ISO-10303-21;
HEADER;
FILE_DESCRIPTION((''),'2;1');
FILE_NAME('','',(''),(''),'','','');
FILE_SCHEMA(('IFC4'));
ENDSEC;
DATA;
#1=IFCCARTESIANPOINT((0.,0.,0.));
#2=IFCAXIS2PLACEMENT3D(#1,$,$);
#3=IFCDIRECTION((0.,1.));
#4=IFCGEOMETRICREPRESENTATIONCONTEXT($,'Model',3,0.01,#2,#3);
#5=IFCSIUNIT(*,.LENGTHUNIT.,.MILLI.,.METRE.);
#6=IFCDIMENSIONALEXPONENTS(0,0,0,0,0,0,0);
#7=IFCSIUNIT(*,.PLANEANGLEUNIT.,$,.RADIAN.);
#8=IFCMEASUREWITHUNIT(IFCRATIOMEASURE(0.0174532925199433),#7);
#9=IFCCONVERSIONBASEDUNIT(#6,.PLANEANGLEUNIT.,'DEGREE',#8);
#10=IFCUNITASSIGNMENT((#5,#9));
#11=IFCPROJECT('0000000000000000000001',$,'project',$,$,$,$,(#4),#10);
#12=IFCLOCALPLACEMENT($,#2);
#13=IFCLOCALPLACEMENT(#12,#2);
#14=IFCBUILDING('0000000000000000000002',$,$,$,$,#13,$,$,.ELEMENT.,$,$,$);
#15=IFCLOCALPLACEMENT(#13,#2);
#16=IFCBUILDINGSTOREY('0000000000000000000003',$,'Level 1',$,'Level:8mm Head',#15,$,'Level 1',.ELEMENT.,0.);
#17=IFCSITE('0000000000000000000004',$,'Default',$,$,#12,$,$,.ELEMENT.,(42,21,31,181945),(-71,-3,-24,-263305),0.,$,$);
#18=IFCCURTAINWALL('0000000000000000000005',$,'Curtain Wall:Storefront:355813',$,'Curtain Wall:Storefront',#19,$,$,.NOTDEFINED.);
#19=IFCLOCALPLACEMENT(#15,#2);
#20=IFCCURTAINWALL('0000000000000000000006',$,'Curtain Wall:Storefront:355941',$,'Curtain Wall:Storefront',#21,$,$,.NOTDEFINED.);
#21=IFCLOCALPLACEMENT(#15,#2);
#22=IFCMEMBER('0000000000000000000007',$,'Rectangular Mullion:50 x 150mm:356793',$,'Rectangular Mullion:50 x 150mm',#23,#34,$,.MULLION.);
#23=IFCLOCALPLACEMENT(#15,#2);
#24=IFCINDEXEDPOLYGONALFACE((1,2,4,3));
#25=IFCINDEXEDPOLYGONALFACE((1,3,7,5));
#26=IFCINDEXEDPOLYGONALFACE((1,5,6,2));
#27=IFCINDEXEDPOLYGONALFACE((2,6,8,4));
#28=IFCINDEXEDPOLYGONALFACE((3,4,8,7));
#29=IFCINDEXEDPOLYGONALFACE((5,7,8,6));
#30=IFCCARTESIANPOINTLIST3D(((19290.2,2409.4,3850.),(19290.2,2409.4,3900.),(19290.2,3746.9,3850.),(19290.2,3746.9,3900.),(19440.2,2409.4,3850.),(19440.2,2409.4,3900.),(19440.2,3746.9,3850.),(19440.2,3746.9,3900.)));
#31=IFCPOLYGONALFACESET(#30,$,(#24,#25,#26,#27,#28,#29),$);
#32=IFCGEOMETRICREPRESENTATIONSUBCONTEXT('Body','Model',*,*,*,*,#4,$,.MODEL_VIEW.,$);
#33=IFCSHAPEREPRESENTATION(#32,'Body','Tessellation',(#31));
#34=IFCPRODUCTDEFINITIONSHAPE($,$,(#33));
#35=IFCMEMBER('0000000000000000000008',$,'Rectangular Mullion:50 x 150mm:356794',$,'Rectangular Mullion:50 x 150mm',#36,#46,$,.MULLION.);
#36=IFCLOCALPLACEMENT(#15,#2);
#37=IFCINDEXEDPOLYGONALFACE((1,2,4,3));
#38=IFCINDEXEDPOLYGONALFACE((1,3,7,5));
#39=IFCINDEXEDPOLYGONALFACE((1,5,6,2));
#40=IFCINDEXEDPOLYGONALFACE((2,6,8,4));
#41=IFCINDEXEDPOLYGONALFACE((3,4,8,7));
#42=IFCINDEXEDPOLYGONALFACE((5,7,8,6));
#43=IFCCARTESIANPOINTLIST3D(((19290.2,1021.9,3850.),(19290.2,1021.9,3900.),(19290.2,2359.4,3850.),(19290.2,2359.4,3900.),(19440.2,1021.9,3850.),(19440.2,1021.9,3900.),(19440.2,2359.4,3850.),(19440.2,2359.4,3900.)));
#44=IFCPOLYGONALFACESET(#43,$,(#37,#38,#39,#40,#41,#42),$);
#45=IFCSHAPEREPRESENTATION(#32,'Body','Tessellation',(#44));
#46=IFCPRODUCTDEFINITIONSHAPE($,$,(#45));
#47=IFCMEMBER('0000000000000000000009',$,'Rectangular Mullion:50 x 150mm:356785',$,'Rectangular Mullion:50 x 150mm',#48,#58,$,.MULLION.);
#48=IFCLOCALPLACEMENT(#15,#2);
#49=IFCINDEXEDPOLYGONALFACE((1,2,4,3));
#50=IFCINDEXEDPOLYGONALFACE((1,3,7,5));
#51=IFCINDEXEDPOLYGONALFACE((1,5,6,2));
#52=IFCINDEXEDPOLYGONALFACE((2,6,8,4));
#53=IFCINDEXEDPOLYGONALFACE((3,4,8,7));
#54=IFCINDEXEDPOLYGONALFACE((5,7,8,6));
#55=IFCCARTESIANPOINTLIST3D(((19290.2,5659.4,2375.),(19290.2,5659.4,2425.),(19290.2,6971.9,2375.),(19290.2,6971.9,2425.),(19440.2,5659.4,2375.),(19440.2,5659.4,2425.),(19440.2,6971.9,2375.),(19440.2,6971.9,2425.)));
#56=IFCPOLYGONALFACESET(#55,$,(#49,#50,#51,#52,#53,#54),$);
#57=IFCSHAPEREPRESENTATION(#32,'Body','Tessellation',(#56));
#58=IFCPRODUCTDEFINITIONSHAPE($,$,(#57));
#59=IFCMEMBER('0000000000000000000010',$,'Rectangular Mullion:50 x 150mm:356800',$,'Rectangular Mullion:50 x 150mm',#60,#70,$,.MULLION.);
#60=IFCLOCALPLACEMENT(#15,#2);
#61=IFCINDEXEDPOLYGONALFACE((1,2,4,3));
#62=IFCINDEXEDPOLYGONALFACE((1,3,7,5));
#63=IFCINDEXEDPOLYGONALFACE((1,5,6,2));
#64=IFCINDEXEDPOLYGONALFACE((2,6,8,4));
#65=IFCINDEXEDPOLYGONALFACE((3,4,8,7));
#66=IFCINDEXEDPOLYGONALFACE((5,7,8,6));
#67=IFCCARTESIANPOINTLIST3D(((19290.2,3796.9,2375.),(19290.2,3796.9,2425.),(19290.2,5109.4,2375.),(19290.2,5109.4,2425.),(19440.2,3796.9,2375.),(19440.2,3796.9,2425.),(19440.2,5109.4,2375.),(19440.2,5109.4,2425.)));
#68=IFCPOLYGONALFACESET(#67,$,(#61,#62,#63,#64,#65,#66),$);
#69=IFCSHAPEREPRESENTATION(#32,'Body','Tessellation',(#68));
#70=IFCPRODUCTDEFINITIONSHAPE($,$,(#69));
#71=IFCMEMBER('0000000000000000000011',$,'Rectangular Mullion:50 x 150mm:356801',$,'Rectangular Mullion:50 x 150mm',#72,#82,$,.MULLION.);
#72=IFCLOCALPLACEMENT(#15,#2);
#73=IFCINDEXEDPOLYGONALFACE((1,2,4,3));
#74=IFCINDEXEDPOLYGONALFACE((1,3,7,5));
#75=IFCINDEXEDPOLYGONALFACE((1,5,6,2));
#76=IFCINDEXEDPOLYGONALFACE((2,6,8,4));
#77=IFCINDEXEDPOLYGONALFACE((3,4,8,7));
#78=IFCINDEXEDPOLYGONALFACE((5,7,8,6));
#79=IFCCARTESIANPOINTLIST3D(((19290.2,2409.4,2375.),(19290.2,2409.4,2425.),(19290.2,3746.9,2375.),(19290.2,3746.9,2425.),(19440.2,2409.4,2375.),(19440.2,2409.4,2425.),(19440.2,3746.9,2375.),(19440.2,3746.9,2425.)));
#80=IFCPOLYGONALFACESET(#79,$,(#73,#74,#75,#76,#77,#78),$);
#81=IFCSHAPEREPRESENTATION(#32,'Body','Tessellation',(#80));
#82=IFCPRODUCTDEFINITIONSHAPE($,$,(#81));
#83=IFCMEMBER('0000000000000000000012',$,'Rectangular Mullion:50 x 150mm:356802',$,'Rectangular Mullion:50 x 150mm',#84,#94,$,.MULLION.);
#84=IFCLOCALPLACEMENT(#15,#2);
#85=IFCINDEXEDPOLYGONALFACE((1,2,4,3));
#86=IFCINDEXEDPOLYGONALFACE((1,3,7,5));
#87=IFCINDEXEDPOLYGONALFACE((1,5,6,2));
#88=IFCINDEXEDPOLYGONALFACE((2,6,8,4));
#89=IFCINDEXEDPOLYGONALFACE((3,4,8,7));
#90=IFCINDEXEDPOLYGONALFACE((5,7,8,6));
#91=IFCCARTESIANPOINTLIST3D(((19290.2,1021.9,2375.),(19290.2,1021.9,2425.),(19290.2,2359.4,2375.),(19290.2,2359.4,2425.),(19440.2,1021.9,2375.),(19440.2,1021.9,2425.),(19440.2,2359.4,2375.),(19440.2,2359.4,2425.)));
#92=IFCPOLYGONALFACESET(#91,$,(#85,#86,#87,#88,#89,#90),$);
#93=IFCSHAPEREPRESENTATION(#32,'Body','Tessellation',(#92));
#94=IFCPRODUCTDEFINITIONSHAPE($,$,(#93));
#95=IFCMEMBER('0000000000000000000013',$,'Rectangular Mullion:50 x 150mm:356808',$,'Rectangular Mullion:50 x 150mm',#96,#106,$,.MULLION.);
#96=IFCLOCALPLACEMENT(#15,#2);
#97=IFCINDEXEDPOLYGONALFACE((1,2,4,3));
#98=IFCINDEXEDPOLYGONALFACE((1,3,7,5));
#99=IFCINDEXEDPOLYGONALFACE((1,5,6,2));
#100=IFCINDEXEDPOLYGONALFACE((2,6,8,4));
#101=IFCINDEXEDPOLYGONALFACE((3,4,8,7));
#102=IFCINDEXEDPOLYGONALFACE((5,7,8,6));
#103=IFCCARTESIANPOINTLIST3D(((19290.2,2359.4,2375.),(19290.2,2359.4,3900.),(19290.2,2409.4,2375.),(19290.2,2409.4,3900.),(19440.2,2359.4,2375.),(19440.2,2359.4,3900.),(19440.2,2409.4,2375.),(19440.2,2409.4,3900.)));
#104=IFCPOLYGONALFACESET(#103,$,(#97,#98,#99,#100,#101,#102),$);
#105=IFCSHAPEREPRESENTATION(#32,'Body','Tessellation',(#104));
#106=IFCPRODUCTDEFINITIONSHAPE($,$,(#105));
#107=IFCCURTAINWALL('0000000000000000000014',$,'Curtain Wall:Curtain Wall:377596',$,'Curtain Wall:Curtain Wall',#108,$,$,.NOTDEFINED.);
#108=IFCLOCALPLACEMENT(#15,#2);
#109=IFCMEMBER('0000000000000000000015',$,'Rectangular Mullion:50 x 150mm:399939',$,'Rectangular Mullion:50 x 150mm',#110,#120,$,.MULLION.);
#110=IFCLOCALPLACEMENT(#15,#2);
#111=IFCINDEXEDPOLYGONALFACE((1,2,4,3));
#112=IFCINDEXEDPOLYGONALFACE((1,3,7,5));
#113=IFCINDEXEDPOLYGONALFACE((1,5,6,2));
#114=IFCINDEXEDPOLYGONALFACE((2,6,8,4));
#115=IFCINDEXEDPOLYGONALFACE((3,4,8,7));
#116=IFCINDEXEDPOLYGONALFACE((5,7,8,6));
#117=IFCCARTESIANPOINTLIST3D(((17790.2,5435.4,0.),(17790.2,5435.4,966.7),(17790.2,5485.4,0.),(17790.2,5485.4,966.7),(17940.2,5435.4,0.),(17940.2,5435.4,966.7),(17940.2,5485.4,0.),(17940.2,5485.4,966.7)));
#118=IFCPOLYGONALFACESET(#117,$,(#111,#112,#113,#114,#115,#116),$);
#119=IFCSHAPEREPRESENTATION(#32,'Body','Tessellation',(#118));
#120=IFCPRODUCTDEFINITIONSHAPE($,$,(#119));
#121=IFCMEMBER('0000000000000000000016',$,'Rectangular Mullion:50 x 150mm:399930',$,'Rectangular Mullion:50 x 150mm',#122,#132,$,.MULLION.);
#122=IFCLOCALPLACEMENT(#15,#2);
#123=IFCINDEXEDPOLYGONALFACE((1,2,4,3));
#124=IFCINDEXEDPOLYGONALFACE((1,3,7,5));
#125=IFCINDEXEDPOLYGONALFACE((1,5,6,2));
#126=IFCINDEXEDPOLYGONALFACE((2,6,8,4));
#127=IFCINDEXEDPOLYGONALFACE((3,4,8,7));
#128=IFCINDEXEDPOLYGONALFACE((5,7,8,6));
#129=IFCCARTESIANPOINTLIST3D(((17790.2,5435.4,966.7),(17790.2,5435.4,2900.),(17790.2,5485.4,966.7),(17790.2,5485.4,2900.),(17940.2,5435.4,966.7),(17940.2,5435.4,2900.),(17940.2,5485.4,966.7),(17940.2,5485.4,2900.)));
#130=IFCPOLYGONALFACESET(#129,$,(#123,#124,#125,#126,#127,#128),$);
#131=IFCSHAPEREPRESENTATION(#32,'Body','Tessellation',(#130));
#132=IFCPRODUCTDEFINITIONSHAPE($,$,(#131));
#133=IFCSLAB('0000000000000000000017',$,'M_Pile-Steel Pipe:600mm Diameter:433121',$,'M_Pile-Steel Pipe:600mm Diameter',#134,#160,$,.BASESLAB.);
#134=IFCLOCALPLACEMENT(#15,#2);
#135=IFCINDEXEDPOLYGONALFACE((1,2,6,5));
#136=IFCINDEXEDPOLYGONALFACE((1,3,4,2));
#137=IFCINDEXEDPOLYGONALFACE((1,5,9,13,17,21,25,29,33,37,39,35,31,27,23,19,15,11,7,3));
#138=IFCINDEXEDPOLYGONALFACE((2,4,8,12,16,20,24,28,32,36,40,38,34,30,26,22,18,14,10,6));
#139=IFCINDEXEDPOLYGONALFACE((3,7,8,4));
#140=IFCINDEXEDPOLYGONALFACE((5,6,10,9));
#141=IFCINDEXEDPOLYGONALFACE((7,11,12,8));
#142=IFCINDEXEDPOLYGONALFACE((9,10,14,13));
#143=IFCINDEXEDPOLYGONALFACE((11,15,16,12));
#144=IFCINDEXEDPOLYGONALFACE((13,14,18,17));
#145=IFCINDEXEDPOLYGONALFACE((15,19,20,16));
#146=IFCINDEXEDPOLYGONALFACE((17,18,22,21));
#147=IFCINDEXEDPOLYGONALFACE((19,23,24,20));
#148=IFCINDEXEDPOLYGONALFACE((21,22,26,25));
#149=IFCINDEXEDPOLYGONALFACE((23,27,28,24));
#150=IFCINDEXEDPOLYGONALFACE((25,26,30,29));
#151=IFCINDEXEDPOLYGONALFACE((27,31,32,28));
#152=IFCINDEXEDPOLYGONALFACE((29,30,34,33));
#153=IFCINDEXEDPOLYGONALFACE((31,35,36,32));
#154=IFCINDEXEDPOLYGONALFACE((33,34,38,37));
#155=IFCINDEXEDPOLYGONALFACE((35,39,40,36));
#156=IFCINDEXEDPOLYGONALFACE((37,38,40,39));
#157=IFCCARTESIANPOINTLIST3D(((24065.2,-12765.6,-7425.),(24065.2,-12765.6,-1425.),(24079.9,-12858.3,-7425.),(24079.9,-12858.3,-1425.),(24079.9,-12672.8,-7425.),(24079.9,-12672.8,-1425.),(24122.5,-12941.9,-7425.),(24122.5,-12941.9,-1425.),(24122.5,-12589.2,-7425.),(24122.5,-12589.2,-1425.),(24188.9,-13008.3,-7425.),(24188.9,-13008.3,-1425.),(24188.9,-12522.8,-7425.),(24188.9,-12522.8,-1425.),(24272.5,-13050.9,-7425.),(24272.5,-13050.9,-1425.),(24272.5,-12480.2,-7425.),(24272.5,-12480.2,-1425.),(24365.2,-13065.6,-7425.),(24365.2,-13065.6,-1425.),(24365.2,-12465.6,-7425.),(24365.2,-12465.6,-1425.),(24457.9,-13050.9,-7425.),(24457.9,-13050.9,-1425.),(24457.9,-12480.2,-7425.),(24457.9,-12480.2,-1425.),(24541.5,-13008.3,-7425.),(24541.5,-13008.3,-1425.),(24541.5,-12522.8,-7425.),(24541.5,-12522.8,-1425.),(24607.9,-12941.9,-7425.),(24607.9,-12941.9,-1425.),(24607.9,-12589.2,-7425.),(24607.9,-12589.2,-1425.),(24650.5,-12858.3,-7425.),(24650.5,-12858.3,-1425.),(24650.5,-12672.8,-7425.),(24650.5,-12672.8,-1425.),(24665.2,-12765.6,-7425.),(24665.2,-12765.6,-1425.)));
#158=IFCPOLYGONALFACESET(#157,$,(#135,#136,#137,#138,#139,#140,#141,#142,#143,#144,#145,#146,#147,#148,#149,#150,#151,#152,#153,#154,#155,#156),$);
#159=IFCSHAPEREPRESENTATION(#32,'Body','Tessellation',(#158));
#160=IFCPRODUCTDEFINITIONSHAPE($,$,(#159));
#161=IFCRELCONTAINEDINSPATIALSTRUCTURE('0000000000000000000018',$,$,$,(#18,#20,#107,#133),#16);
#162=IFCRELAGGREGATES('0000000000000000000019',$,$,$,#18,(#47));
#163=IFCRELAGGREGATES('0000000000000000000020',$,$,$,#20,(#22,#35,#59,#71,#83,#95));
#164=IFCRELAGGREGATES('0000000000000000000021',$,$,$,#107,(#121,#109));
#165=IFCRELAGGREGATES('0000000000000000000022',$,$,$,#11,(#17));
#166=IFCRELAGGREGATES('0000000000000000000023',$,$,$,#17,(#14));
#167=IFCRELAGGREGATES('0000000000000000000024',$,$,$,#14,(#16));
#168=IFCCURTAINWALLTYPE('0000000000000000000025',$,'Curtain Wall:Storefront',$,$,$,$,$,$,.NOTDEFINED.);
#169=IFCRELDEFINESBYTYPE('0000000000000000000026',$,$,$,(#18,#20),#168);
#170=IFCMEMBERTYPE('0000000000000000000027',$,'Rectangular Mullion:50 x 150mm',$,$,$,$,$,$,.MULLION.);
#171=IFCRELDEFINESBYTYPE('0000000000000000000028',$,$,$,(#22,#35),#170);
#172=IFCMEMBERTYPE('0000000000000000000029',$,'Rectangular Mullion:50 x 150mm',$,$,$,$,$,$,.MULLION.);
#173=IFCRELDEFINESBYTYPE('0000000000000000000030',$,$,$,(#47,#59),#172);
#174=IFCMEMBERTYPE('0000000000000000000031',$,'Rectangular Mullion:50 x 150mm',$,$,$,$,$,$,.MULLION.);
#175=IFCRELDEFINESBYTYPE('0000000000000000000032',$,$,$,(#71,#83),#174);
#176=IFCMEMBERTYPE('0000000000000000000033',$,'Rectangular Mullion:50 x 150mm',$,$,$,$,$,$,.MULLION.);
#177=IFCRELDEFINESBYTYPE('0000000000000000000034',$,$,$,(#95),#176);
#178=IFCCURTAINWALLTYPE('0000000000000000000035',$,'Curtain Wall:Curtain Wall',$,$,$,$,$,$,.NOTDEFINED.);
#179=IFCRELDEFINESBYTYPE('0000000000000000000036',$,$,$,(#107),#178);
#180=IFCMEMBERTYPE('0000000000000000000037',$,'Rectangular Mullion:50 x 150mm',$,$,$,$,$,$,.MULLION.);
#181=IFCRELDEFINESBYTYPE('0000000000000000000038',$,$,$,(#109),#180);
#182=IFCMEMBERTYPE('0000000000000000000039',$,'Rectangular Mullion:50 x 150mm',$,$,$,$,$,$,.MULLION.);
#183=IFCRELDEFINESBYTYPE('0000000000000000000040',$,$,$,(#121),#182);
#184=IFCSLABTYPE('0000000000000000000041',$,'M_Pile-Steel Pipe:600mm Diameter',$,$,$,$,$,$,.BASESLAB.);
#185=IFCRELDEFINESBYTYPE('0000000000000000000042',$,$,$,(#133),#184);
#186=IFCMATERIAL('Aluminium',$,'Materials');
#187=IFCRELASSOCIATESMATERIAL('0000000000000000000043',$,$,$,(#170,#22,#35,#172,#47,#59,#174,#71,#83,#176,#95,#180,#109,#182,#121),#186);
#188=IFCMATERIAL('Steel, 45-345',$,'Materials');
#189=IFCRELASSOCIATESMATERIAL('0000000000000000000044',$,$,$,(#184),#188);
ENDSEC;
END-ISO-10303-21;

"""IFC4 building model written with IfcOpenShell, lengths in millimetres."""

from ifc_helpers import new_model, entity, si_unit, converted_unit, direction, frame, origin, place, context, subcontext, project, spatial, indexed_curve, outline, extrude, source, transform, mapped, material, type_object, type_shapes, element, aggregate, save


model = new_model("IFC4")

# Units and contexts
model_context = context("Model", 3, precision=0.01, world=origin(), true_north=direction((0.0, 1.0)))
body_context = subcontext(model_context, "Body", "Model", "MODEL_VIEW")
ifc_project = project(units=[si_unit("LENGTHUNIT", "METRE", prefix="MILLI"), converted_unit("PLANEANGLEUNIT", "DEGREE", entity("IfcRatioMeasure", 0.0174532925199433), si_unit("PLANEANGLEUNIT", "RADIAN"), dimensions=[0, 0, 0, 0, 0, 0, 0])], contexts=[model_context])

# Site, building, storey
site_placement = place(None, origin())
site = spatial("IfcSite", under=ifc_project, at=site_placement, Name="Default", CompositionType="ELEMENT", RefLatitude=(42, 21, 31, 181945), RefLongitude=(-71, -3, -24, -263305), RefElevation=0.0)
building_placement = place(site_placement, origin())
building = spatial("IfcBuilding", under=site, at=building_placement, CompositionType="ELEMENT")
storey_placement = place(building_placement, origin())
storey = spatial("IfcBuildingStorey", under=building, at=storey_placement, Name="Level 1", ObjectType="Level:8mm Head", LongName="Level 1", CompositionType="ELEMENT", Elevation=0.0)

# Curtain walls
curtain_wall_type_1 = type_object("IfcCurtainWallType", Name="Curtain Wall:Storefront", PredefinedType="NOTDEFINED")
curtain_wall_1_placement = place(storey_placement, origin())
curtain_wall_1 = element("IfcCurtainWall", 1, at=curtain_wall_1_placement, inside=storey, type_object=curtain_wall_type_1, Name="Curtain Wall:Storefront:355813", ObjectType="Curtain Wall:Storefront", PredefinedType="NOTDEFINED")
ifc_material_1 = material(Name="Aluminium", Category="Materials")
curtain_wall_2_placement = place(storey_placement, origin())
curtain_wall_2 = element("IfcCurtainWall", 2, at=curtain_wall_2_placement, inside=storey, type_object=curtain_wall_type_1, Name="Curtain Wall:Storefront:355941", ObjectType="Curtain Wall:Storefront", PredefinedType="NOTDEFINED")

# Members
member_type_1 = type_object("IfcMemberType", Name="Rectangular Mullion:50 x 150mm", PredefinedType="MULLION", material=ifc_material_1)
shared_shape_1 = source(origin(), body_context, "Body", "SweptSolid", [
    extrude(outline(indexed_curve([(-75.0, -25.0), (75.0, -25.0), (75.0, 25.0), (-75.0, 25.0), (-75.0, -25.0)], self_intersect=False)), frame((-25.0, 0.0, -1337.5), z_axis=(0.0, 0.0, 1.0), x_axis=(0.0, -1.0, 0.0)), (0.0, 0.0, 1.0), 1337.5),
])
type_shapes(member_type_1, [shared_shape_1])
member_1_placement = place(storey_placement, frame((19365.2, 2409.4, 3900.0), z_axis=(0.0, -1.0, 0.0), x_axis=(0.0, 0.0, 1.0)))
member_1 = element("IfcMember", 3, at=member_1_placement, type_object=member_type_1, material=ifc_material_1, Name="Rectangular Mullion:50 x 150mm:356793", ObjectType="Rectangular Mullion:50 x 150mm", PredefinedType="MULLION", context=body_context, shape_type="MappedRepresentation", body=[
    mapped(shared_shape_1, transform((0.0, 0.0, 0.0), scale=1.0)),
])
member_2_placement = place(storey_placement, frame((19365.2, 1021.9, 3900.0), z_axis=(0.0, -1.0, 0.0), x_axis=(0.0, 0.0, 1.0)))
member_2 = element("IfcMember", 4, at=member_2_placement, type_object=member_type_1, material=ifc_material_1, Name="Rectangular Mullion:50 x 150mm:356794", ObjectType="Rectangular Mullion:50 x 150mm", PredefinedType="MULLION", context=body_context, shape_type="MappedRepresentation", body=[
    mapped(shared_shape_1, transform((0.0, 0.0, 0.0), scale=1.0)),
])
member_type_2 = type_object("IfcMemberType", Name="Rectangular Mullion:50 x 150mm", PredefinedType="MULLION", material=ifc_material_1)
shared_shape_2 = source(origin(), body_context, "Body", "SweptSolid", [
    extrude(outline(indexed_curve([(-75.0, -25.0), (75.0, -25.0), (75.0, 25.0), (-75.0, 25.0), (-75.0, -25.0)], self_intersect=False)), frame((0.0, 0.0, -1312.5), z_axis=(0.0, 0.0, 1.0), x_axis=(0.0, -1.0, 0.0)), (0.0, 0.0, 1.0), 1312.5),
])
type_shapes(member_type_2, [shared_shape_2])
member_3_placement = place(storey_placement, frame((19365.2, 5659.4, 2400.0), z_axis=(0.0, -1.0, 0.0), x_axis=(0.0, 0.0, 1.0)))
member_3 = element("IfcMember", 5, at=member_3_placement, type_object=member_type_2, material=ifc_material_1, Name="Rectangular Mullion:50 x 150mm:356785", ObjectType="Rectangular Mullion:50 x 150mm", PredefinedType="MULLION", context=body_context, shape_type="MappedRepresentation", body=[
    mapped(shared_shape_2, transform((0.0, 0.0, 0.0), scale=1.0)),
])
member_4_placement = place(storey_placement, frame((19365.2, 3796.9, 2400.0), z_axis=(0.0, -1.0, 0.0), x_axis=(0.0, 0.0, 1.0)))
member_4 = element("IfcMember", 6, at=member_4_placement, type_object=member_type_2, material=ifc_material_1, Name="Rectangular Mullion:50 x 150mm:356800", ObjectType="Rectangular Mullion:50 x 150mm", PredefinedType="MULLION", context=body_context, shape_type="MappedRepresentation", body=[
    mapped(shared_shape_2, transform((0.0, 0.0, 0.0), scale=1.0)),
])
member_type_3 = type_object("IfcMemberType", Name="Rectangular Mullion:50 x 150mm", PredefinedType="MULLION", material=ifc_material_1)
shared_shape_3 = source(origin(), body_context, "Body", "SweptSolid", [
    extrude(outline(indexed_curve([(-75.0, -25.0), (75.0, -25.0), (75.0, 25.0), (-75.0, 25.0), (-75.0, -25.0)], self_intersect=False)), frame((0.0, 0.0, -1337.5), z_axis=(0.0, 0.0, 1.0), x_axis=(0.0, -1.0, 0.0)), (0.0, 0.0, 1.0), 1337.5),
])
type_shapes(member_type_3, [shared_shape_3])
member_5_placement = place(storey_placement, frame((19365.2, 2409.4, 2400.0), z_axis=(0.0, -1.0, 0.0), x_axis=(0.0, 0.0, 1.0)))
member_5 = element("IfcMember", 7, at=member_5_placement, type_object=member_type_3, material=ifc_material_1, Name="Rectangular Mullion:50 x 150mm:356801", ObjectType="Rectangular Mullion:50 x 150mm", PredefinedType="MULLION", context=body_context, shape_type="MappedRepresentation", body=[
    mapped(shared_shape_3, transform((0.0, 0.0, 0.0), scale=1.0)),
])
member_6_placement = place(storey_placement, frame((19365.2, 1021.9, 2400.0), z_axis=(0.0, -1.0, 0.0), x_axis=(0.0, 0.0, 1.0)))
member_6 = element("IfcMember", 8, at=member_6_placement, type_object=member_type_3, material=ifc_material_1, Name="Rectangular Mullion:50 x 150mm:356802", ObjectType="Rectangular Mullion:50 x 150mm", PredefinedType="MULLION", context=body_context, shape_type="MappedRepresentation", body=[
    mapped(shared_shape_3, transform((0.0, 0.0, 0.0), scale=1.0)),
])
member_type_4 = type_object("IfcMemberType", Name="Rectangular Mullion:50 x 150mm", PredefinedType="MULLION", material=ifc_material_1)
shared_shape_4 = source(origin(), body_context, "Body", "SweptSolid", [
    extrude(outline(indexed_curve([(-75.0, -25.0), (75.0, -25.0), (75.0, 25.0), (-75.0, 25.0), (-75.0, -25.0)], self_intersect=False)), frame((0.0, 0.0, -1525.0), z_axis=(0.0, 0.0, 1.0), x_axis=(0.0, -1.0, 0.0)), (0.0, 0.0, 1.0), 1525.0),
])
type_shapes(member_type_4, [shared_shape_4])
member_7_placement = place(storey_placement, frame((19365.2, 2384.4, 2375.0), z_axis=(0.0, 0.0, -1.0), x_axis=(0.0, -1.0, 0.0)))
member_7 = element("IfcMember", 9, at=member_7_placement, type_object=member_type_4, material=ifc_material_1, Name="Rectangular Mullion:50 x 150mm:356808", ObjectType="Rectangular Mullion:50 x 150mm", PredefinedType="MULLION", context=body_context, shape_type="MappedRepresentation", body=[
    mapped(shared_shape_4, transform((0.0, 0.0, 0.0), scale=1.0)),
])

# Curtain wall, members
curtain_wall_type_2 = type_object("IfcCurtainWallType", Name="Curtain Wall:Curtain Wall", PredefinedType="NOTDEFINED")
curtain_wall_3_placement = place(storey_placement, origin())
curtain_wall_3 = element("IfcCurtainWall", 10, at=curtain_wall_3_placement, inside=storey, type_object=curtain_wall_type_2, Name="Curtain Wall:Curtain Wall:377596", ObjectType="Curtain Wall:Curtain Wall", PredefinedType="NOTDEFINED")
member_type_5 = type_object("IfcMemberType", Name="Rectangular Mullion:50 x 150mm", PredefinedType="MULLION", material=ifc_material_1)
shared_shape_5 = source(origin(), body_context, "Body", "SweptSolid", [
    extrude(outline(indexed_curve([(-75.0, -25.0), (75.0, -25.0), (75.0, 25.0), (-75.0, 25.0), (-75.0, -25.0)], self_intersect=False)), frame((-25.0, 0.0, -966.7), z_axis=(0.0, 0.0, 1.0), x_axis=(0.0, -1.0, 0.0)), (0.0, 0.0, 1.0), 966.7),
])
type_shapes(member_type_5, [shared_shape_5])
member_8_placement = place(storey_placement, frame((17865.2, 5435.4, 966.7), z_axis=(0.0, 0.0, 1.0), x_axis=(0.0, -1.0, 0.0)))
member_8 = element("IfcMember", 11, at=member_8_placement, type_object=member_type_5, material=ifc_material_1, Name="Rectangular Mullion:50 x 150mm:399939", ObjectType="Rectangular Mullion:50 x 150mm", PredefinedType="MULLION", context=body_context, shape_type="MappedRepresentation", body=[
    mapped(shared_shape_5, transform((0.0, 0.0, 0.0), scale=1.0)),
])
member_type_6 = type_object("IfcMemberType", Name="Rectangular Mullion:50 x 150mm", PredefinedType="MULLION", material=ifc_material_1)
shared_shape_6 = source(origin(), body_context, "Body", "SweptSolid", [
    extrude(outline(indexed_curve([(-75.0, -25.0), (75.0, -25.0), (75.0, 25.0), (-75.0, 25.0), (-75.0, -25.0)], self_intersect=False)), frame((-25.0, 0.0, -1933.3), z_axis=(0.0, 0.0, 1.0), x_axis=(0.0, -1.0, 0.0)), (0.0, 0.0, 1.0), 1933.3),
])
type_shapes(member_type_6, [shared_shape_6])
member_9_placement = place(storey_placement, frame((17865.2, 5435.4, 2900.0), z_axis=(0.0, 0.0, 1.0), x_axis=(0.0, -1.0, 0.0)))
member_9 = element("IfcMember", 12, at=member_9_placement, type_object=member_type_6, material=ifc_material_1, Name="Rectangular Mullion:50 x 150mm:399930", ObjectType="Rectangular Mullion:50 x 150mm", PredefinedType="MULLION", context=body_context, shape_type="MappedRepresentation", body=[
    mapped(shared_shape_6, transform((0.0, 0.0, 0.0), scale=1.0)),
])

aggregate(curtain_wall_1, [member_3])

# Slab
ifc_material_2 = material(Name="Steel, 45-345", Category="Materials")
slab_type_1 = type_object("IfcSlabType", Name="M_Pile-Steel Pipe:600mm Diameter", PredefinedType="BASESLAB", material=ifc_material_2)
slab_1_placement = place(building_placement, origin())
element("IfcSlab", 13, at=slab_1_placement, inside=storey, type_object=slab_type_1, Name="M_Pile-Steel Pipe:600mm Diameter:433121", ObjectType="M_Pile-Steel Pipe:600mm Diameter", PredefinedType="BASESLAB", context=body_context, shape_type="SweptSolid", body=[
    extrude(outline(indexed_curve([(300.0, 0.0), (285.3, 92.7), (242.7, 176.3), (176.3, 242.7), (92.7, 285.3), (0.0, 300.0), (-92.7, 285.3), (-176.3, 242.7), (-242.7, 176.3), (-285.3, 92.7), (-300.0, 0.0), (-285.3, -92.7), (-242.7, -176.3), (-176.3, -242.7), (-92.7, -285.3), (0.0, -300.0), (92.7, -285.3), (176.3, -242.7), (242.7, -176.3), (285.3, -92.7), (300.0, 0.0)], self_intersect=False)), frame((24365.2, -12765.6, -7425.0)), (0.0, 0.0, 1.0), 6000.0),
])

aggregate(curtain_wall_2, [member_1, member_2, member_4, member_5, member_6, member_7])

aggregate(curtain_wall_3, [member_9, member_8])

save(model, "model.ifc")
